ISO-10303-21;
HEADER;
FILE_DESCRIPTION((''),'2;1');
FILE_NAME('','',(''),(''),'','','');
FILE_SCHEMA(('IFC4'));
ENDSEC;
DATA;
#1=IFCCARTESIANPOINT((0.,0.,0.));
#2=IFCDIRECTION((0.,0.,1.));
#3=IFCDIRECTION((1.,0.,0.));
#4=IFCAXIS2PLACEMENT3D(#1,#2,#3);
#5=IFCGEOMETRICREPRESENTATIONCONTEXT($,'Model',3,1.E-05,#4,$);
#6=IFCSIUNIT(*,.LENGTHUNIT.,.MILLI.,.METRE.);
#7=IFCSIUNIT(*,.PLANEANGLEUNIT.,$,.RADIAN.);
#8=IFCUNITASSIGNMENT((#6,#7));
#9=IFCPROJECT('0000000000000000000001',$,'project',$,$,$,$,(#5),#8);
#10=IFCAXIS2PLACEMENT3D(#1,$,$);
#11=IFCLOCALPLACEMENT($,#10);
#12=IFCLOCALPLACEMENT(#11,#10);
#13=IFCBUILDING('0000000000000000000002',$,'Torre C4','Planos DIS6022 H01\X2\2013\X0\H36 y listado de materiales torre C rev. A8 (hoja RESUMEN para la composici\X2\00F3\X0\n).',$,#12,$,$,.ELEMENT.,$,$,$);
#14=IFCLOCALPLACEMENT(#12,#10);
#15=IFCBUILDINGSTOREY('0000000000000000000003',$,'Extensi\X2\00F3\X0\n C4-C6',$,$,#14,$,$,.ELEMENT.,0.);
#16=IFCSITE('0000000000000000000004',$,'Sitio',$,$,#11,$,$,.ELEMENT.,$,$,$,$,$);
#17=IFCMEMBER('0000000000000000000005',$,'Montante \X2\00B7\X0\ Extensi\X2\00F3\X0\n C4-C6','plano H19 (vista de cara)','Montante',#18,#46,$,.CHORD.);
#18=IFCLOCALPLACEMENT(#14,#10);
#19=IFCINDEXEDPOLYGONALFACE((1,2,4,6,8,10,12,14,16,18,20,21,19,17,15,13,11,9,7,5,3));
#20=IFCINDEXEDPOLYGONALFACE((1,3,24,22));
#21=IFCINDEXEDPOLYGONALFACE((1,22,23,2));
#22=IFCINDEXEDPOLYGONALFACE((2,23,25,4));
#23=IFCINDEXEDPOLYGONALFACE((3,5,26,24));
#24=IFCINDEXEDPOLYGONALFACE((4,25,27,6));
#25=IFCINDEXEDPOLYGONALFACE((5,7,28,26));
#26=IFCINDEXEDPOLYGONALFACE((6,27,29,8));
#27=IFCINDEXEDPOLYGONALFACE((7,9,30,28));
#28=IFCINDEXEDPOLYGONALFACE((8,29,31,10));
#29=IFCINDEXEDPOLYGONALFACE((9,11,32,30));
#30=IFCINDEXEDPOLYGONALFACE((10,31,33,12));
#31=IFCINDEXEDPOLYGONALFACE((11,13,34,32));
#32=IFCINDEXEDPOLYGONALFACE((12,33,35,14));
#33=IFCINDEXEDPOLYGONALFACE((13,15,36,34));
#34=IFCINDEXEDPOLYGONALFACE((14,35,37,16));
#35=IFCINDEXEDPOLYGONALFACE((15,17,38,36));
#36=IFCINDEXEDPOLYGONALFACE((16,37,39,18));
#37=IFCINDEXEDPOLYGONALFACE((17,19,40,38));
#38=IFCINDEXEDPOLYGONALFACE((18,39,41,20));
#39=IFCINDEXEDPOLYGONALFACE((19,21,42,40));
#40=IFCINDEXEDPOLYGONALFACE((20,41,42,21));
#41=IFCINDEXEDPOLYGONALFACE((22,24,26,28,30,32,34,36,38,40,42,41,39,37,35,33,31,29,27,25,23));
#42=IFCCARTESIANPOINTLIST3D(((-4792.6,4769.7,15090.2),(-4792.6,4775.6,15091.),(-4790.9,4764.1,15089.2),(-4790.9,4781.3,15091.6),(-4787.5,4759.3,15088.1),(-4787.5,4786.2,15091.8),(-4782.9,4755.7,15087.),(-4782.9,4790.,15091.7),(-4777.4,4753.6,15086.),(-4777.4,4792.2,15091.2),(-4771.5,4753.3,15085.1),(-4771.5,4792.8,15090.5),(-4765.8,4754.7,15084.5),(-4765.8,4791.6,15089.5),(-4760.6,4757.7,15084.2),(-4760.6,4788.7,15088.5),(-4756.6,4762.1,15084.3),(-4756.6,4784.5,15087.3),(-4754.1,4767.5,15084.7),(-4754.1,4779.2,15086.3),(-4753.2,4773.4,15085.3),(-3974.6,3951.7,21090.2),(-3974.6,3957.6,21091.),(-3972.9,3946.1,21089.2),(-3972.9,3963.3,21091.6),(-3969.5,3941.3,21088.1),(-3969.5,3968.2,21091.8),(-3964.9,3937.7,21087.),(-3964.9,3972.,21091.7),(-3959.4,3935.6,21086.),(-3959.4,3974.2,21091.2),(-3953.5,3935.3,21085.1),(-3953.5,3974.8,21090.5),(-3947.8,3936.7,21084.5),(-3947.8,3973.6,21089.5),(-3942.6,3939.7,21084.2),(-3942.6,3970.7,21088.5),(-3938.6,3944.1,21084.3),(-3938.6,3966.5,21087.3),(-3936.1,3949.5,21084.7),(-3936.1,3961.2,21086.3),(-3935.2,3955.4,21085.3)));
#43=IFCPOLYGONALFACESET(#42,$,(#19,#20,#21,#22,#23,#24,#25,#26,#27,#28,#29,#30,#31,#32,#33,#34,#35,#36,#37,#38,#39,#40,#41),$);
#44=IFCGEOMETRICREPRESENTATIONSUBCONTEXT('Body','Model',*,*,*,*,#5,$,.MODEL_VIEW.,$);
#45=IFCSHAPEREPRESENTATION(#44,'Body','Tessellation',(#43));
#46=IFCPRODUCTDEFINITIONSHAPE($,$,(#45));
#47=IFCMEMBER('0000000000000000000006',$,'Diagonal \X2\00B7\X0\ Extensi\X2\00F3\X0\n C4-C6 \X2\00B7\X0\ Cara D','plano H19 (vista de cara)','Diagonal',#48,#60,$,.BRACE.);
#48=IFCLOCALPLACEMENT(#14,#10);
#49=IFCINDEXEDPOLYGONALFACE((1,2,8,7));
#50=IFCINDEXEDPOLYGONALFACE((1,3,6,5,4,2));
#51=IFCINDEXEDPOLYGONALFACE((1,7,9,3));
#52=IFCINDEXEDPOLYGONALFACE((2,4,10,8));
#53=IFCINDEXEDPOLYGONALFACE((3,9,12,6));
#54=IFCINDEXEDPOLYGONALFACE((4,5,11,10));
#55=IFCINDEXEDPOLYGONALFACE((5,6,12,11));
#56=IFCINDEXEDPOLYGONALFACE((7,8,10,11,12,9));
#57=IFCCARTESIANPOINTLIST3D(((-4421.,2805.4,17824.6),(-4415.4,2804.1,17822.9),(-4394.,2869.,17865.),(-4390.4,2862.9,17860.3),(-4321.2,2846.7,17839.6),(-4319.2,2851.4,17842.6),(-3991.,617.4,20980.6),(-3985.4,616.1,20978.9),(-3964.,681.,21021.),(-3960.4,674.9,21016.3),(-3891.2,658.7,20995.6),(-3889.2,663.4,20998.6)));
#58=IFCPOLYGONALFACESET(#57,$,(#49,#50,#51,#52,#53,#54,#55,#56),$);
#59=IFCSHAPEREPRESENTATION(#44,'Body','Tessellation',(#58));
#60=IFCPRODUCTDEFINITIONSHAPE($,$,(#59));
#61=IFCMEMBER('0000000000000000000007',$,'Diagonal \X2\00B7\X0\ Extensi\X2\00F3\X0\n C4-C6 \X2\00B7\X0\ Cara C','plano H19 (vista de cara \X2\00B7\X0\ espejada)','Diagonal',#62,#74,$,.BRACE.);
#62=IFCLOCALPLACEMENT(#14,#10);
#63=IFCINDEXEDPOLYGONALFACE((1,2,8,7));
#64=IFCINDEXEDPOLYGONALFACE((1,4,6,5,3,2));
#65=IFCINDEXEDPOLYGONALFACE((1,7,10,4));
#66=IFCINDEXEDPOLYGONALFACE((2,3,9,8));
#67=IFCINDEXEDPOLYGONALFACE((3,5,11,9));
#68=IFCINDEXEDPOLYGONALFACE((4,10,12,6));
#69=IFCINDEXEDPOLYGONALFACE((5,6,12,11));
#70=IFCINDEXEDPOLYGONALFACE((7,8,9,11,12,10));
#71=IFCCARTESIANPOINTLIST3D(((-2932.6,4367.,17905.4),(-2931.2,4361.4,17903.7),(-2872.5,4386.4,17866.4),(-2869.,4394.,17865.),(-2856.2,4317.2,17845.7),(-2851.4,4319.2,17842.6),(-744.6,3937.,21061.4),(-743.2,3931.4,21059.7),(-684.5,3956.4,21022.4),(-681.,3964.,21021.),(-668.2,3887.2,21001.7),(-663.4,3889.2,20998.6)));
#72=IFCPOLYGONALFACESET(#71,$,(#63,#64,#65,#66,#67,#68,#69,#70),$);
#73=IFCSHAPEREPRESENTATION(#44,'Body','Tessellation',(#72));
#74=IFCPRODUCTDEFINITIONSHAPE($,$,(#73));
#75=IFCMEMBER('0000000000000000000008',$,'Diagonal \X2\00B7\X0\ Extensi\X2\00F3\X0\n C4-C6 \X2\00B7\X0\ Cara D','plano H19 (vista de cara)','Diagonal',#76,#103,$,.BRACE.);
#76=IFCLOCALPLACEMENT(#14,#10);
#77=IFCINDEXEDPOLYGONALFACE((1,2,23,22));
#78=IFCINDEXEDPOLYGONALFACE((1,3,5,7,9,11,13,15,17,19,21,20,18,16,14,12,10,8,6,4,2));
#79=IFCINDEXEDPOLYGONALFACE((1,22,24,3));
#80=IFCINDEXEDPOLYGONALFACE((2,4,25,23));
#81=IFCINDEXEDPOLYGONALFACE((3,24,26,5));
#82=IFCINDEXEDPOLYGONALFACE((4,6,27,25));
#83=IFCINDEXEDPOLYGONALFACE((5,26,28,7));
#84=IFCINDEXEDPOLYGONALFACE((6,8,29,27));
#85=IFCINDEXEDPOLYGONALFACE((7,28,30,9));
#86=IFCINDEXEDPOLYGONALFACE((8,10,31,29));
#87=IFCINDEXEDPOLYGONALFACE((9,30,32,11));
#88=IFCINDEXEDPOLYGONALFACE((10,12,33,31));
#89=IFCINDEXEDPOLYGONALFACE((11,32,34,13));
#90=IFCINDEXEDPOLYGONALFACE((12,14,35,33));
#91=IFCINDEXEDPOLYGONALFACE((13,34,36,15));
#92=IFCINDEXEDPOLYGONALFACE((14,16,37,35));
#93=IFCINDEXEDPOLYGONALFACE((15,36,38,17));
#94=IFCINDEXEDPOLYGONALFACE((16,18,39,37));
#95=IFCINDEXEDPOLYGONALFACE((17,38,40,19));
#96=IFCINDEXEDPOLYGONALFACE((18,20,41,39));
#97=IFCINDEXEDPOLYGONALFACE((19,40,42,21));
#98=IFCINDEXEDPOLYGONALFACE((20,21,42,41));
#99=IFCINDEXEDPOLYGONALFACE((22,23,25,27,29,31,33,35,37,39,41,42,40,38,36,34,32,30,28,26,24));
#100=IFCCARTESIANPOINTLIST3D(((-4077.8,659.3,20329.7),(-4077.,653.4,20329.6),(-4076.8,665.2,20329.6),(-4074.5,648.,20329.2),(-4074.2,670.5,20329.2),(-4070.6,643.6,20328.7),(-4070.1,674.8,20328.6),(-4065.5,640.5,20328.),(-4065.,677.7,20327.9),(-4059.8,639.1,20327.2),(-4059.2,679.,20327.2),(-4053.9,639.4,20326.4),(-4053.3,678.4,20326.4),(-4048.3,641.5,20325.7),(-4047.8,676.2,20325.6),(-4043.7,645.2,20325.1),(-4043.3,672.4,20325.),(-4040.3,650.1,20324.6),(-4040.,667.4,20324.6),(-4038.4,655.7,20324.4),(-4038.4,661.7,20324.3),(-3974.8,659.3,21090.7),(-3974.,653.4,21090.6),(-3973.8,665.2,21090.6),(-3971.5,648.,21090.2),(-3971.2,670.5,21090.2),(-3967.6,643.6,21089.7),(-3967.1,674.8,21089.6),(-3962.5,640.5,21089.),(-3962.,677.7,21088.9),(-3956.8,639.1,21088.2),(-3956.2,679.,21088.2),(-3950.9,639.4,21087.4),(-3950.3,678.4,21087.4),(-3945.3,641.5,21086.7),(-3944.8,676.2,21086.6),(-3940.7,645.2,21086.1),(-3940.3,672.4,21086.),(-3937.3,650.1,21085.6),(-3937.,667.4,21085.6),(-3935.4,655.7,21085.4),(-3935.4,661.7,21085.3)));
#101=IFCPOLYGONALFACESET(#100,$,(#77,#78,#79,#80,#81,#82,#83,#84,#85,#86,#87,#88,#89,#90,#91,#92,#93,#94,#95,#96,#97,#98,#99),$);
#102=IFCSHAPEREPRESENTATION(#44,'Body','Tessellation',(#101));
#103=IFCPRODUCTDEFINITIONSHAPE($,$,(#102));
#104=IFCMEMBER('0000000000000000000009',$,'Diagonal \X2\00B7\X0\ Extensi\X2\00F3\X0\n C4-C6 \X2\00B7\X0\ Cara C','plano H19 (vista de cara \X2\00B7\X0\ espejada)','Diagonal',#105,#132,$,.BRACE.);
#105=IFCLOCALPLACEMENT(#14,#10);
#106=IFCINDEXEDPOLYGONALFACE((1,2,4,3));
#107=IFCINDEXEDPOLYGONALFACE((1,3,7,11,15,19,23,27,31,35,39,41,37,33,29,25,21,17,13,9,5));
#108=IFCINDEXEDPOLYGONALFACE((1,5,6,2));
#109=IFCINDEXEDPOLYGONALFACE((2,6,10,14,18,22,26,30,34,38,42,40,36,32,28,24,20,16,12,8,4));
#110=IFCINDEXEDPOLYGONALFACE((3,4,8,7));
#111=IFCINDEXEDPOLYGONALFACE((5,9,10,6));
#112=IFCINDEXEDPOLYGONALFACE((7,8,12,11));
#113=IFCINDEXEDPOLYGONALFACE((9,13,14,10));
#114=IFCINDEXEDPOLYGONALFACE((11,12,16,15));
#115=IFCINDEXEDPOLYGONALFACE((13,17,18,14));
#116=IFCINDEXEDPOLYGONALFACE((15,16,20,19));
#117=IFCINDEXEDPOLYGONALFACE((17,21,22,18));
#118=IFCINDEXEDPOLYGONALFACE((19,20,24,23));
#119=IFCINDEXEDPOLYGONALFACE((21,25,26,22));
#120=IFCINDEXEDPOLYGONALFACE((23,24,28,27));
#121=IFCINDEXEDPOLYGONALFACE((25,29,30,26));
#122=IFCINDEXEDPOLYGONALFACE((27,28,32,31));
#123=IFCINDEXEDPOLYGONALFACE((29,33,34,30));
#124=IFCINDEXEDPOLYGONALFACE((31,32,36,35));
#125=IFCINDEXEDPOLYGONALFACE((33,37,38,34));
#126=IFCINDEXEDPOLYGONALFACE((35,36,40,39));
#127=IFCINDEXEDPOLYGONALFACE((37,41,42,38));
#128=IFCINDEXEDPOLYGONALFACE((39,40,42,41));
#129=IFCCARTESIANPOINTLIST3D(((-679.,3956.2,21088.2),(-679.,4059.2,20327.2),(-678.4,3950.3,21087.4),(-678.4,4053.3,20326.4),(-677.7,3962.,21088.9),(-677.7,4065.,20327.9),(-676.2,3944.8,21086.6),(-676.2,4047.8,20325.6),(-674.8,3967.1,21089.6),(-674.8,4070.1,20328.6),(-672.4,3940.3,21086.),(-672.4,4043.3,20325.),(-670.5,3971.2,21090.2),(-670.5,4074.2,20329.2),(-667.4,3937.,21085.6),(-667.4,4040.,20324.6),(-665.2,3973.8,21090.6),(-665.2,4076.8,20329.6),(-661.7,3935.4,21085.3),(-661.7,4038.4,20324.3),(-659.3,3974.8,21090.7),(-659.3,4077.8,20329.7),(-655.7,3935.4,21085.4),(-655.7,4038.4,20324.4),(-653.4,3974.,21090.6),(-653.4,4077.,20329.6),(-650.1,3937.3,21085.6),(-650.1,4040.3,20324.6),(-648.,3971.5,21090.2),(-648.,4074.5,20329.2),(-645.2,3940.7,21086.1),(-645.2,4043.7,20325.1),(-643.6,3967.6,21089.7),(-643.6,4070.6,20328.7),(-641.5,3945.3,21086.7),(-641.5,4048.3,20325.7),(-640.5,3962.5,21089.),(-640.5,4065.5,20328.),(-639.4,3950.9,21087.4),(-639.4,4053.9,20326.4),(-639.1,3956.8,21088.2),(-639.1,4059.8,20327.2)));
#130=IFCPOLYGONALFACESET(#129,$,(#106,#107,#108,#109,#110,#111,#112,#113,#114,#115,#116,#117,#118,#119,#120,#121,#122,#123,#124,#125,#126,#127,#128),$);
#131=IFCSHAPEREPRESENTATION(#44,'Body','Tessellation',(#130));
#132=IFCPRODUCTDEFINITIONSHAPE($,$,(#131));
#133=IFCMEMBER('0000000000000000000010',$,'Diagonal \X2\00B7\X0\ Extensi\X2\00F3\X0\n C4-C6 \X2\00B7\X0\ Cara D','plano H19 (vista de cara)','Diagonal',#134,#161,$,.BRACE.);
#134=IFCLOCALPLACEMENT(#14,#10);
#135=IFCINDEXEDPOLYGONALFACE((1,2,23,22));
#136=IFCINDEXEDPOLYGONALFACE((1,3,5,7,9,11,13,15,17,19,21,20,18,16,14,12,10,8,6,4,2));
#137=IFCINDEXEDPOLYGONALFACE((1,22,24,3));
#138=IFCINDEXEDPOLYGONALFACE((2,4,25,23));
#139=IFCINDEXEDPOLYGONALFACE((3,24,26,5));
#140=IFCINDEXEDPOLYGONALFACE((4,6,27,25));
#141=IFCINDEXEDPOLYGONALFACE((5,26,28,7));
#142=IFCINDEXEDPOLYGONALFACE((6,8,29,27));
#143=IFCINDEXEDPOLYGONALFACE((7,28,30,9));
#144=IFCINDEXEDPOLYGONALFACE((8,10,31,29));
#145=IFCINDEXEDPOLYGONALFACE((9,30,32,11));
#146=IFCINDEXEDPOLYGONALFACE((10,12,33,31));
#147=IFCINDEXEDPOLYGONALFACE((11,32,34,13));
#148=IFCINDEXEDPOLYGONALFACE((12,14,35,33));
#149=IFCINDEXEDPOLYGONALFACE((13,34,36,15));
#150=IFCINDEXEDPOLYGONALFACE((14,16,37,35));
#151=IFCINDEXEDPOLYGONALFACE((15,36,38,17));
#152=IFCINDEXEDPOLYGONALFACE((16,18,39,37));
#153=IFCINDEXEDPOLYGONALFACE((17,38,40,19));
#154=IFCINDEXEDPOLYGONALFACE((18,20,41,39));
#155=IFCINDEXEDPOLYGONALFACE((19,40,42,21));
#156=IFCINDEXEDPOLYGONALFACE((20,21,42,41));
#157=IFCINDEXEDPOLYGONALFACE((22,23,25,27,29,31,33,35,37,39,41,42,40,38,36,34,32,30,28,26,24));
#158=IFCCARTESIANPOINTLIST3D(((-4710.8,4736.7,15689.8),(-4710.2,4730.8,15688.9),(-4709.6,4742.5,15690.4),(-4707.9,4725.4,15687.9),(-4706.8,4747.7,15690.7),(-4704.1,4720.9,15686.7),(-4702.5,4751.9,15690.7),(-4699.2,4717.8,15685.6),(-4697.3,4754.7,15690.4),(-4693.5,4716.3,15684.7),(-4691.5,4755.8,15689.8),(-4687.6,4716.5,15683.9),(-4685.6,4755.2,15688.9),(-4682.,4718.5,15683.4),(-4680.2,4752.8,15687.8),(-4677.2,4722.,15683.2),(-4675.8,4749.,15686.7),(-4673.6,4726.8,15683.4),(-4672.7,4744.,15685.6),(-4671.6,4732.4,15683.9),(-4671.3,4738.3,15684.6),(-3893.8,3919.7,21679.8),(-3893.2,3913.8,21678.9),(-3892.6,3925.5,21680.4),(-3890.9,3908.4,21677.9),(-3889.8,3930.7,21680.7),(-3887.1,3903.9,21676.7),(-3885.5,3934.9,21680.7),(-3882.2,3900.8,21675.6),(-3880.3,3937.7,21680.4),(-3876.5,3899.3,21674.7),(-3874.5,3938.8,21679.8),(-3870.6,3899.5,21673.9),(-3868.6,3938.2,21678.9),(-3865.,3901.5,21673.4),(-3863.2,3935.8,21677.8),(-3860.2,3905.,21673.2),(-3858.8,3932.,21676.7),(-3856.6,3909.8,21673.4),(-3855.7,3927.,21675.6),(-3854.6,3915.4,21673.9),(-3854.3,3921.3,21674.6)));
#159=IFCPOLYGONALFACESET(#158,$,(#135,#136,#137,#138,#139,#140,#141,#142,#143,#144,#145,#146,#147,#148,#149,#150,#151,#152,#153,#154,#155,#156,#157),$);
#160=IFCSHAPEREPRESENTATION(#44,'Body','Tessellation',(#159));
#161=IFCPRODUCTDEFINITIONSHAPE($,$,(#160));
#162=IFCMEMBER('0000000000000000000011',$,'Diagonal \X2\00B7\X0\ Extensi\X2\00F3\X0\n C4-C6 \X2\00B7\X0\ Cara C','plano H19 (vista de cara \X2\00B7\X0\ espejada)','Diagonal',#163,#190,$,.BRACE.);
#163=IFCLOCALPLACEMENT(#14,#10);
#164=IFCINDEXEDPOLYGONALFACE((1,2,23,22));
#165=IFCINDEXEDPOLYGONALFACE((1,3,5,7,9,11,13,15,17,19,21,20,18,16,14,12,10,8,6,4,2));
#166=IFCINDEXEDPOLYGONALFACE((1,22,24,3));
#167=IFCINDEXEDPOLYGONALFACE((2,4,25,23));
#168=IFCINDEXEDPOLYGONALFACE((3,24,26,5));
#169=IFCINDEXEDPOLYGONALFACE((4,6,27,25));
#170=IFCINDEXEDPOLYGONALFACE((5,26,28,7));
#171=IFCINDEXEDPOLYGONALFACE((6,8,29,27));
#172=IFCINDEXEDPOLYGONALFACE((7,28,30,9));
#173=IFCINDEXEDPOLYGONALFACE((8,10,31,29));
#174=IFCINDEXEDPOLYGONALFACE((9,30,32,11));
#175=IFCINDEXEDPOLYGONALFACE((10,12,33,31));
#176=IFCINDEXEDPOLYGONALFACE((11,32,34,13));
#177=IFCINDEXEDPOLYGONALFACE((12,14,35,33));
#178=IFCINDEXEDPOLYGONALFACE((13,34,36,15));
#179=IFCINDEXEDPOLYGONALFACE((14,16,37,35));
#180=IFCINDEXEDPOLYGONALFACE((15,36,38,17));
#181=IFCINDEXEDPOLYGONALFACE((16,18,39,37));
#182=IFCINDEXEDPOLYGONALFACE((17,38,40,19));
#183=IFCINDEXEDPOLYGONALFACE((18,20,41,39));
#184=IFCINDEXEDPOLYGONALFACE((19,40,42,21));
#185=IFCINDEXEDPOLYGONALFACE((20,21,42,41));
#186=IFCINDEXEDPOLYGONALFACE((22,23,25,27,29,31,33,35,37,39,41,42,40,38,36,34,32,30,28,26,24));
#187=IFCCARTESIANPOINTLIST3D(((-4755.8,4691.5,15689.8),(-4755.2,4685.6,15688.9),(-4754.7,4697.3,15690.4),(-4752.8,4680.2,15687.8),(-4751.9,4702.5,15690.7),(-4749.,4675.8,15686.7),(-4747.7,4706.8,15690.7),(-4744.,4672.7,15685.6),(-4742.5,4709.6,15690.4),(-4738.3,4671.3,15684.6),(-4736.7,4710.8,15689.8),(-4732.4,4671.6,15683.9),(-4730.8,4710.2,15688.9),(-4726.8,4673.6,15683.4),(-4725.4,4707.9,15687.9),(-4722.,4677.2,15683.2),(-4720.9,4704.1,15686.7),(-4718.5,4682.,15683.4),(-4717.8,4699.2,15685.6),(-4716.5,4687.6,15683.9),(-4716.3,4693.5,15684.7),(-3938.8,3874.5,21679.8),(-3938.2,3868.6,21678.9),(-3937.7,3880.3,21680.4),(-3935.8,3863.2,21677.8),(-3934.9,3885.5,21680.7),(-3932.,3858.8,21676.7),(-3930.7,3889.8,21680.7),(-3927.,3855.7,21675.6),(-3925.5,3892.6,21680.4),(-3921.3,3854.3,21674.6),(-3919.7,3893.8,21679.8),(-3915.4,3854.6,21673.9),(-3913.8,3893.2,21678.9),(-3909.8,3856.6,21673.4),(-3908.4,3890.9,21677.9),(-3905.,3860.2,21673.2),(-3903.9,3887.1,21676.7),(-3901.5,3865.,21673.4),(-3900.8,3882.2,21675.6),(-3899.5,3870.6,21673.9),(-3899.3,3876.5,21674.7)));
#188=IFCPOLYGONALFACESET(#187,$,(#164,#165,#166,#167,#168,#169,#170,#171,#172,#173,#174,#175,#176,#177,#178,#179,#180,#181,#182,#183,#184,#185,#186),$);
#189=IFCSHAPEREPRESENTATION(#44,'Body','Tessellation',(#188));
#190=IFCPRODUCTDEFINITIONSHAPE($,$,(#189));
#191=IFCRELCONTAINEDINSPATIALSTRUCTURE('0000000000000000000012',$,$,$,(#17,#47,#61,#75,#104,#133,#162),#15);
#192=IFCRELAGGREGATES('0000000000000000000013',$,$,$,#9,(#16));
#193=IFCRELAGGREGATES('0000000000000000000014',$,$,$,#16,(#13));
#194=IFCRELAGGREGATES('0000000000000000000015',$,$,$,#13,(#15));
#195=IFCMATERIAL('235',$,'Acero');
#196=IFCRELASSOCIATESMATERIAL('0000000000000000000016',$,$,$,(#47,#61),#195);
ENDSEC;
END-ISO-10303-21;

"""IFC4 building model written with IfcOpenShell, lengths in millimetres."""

from ifc_helpers import new_model, si_unit, frame, frame_2d, origin, origin_with_axes, place, context, subcontext, project, spatial, circle, l_section, extrude, material, element, save


model = new_model("IFC4")

# Units and contexts
model_context = context("Model", 3, precision=1e-05, world=origin_with_axes())
body_context = subcontext(model_context, "Body", "Model", "MODEL_VIEW")
ifc_project = project(units=[si_unit("LENGTHUNIT", "METRE", prefix="MILLI"), si_unit("PLANEANGLEUNIT", "RADIAN")], contexts=[model_context])

# Site, building, storey
site_placement = place(None, origin())
site = spatial("IfcSite", under=ifc_project, at=site_placement, Name="Sitio", CompositionType="ELEMENT")
building_placement = place(site_placement, origin())
building = spatial("IfcBuilding", under=site, at=building_placement, Name="Torre C4", Description="Planos DIS6022 H01–H36 y listado de materiales torre C rev. A8 (hoja RESUMEN para la composición).", CompositionType="ELEMENT")
storey_placement = place(building_placement, origin())
storey = spatial("IfcBuildingStorey", under=building, at=storey_placement, Name="Extensión C4-C6", CompositionType="ELEMENT", Elevation=0.0)

# Members
member_placement = place(storey_placement, frame((-3955.0, 3955.0, 21088.0), z_axis=(-0.133868, 0.133868, -0.981916), x_axis=(0.990999, 0.018083, -0.132641)))
element("IfcMember", 1, at=member_placement, inside=storey, Name="Montante · Extensión C4-C6", Description="plano H19 (vista de cara)", ObjectType="Montante", PredefinedType="CHORD", context=body_context, shape_type="SweptSolid", body=[
    extrude(circle(Radius=20.0), None, (0.0, 0.0, 1.0), 6110.5),
])
ifc_material = material(Name="235", Category="Acero")
for number, where, z_axis, x_axis, name, description in (
    (2, (-3964.0, 681.0, 21021.0), (-0.111276, 0.566213, -0.816713), (0.934738, -0.219434, -0.279487), "Diagonal · Extensión C4-C6 · Cara D", "plano H19 (vista de cara)"),
    (3, (-681.0, 3964.0, 21021.0), (-0.566213, 0.111276, -0.816713), (0.219434, -0.934738, -0.279487), "Diagonal · Extensión C4-C6 · Cara C", "plano H19 (vista de cara · espejada)"),
):
    element("IfcMember", number, at=place(storey_placement, frame(where, z_axis=z_axis, x_axis=x_axis)), inside=storey, material=ifc_material, Name=name, Description=description, ObjectType="Diagonal", PredefinedType="BRACE", context=body_context, shape_type="SweptSolid", body=[
        extrude(l_section(Depth=80.0, Width=80.0, Thickness=6.0, at=frame_2d((40.0, 40.0))), None, (0.0, 0.0, 1.0), 3864.3),
    ])
for number, where, z_axis, x_axis, name, description in (
    (4, (-4058.0, 659.0, 20327.0), (0.134125, 0.0, 0.990964), (0.977589, -0.163742, -0.132315), "Diagonal · Extensión C4-C6 · Cara D", "plano H19 (vista de cara)"),
    (5, (-659.0, 4058.0, 20327.0), (0.0, -0.134125, 0.990964), (0.163742, -0.977589, -0.132315), "Diagonal · Extensión C4-C6 · Cara C", "plano H19 (vista de cara · espejada)"),
):
    element("IfcMember", number, at=place(storey_placement, frame(where, z_axis=z_axis, x_axis=x_axis)), inside=storey, Name=name, Description=description, ObjectType="Diagonal", PredefinedType="BRACE", context=body_context, shape_type="SweptSolid", body=[
        extrude(circle(Radius=20.0), None, (0.0, 0.0, 1.0), 767.9),
    ])
for number, where, z_axis, x_axis, name, description in (
    (6, (-4691.0, 4736.0, 15687.0), (0.133925, -0.133925, 0.9819), (0.690535, -0.698062, -0.189396), "Diagonal · Extensión C4-C6 · Cara D", "plano H19 (vista de cara)"),
    (7, (-4736.0, 4691.0, 15687.0), (0.133925, -0.133925, 0.9819), (0.698062, -0.690535, -0.189396), "Diagonal · Extensión C4-C6 · Cara C", "plano H19 (vista de cara · espejada)"),
):
    element("IfcMember", number, at=place(storey_placement, frame(where, z_axis=z_axis, x_axis=x_axis)), inside=storey, Name=name, Description=description, ObjectType="Diagonal", PredefinedType="BRACE", context=body_context, shape_type="SweptSolid", body=[
        extrude(circle(Radius=20.0), None, (0.0, 0.0, 1.0), 6100.4),
    ])

save(model, "model.ifc")
